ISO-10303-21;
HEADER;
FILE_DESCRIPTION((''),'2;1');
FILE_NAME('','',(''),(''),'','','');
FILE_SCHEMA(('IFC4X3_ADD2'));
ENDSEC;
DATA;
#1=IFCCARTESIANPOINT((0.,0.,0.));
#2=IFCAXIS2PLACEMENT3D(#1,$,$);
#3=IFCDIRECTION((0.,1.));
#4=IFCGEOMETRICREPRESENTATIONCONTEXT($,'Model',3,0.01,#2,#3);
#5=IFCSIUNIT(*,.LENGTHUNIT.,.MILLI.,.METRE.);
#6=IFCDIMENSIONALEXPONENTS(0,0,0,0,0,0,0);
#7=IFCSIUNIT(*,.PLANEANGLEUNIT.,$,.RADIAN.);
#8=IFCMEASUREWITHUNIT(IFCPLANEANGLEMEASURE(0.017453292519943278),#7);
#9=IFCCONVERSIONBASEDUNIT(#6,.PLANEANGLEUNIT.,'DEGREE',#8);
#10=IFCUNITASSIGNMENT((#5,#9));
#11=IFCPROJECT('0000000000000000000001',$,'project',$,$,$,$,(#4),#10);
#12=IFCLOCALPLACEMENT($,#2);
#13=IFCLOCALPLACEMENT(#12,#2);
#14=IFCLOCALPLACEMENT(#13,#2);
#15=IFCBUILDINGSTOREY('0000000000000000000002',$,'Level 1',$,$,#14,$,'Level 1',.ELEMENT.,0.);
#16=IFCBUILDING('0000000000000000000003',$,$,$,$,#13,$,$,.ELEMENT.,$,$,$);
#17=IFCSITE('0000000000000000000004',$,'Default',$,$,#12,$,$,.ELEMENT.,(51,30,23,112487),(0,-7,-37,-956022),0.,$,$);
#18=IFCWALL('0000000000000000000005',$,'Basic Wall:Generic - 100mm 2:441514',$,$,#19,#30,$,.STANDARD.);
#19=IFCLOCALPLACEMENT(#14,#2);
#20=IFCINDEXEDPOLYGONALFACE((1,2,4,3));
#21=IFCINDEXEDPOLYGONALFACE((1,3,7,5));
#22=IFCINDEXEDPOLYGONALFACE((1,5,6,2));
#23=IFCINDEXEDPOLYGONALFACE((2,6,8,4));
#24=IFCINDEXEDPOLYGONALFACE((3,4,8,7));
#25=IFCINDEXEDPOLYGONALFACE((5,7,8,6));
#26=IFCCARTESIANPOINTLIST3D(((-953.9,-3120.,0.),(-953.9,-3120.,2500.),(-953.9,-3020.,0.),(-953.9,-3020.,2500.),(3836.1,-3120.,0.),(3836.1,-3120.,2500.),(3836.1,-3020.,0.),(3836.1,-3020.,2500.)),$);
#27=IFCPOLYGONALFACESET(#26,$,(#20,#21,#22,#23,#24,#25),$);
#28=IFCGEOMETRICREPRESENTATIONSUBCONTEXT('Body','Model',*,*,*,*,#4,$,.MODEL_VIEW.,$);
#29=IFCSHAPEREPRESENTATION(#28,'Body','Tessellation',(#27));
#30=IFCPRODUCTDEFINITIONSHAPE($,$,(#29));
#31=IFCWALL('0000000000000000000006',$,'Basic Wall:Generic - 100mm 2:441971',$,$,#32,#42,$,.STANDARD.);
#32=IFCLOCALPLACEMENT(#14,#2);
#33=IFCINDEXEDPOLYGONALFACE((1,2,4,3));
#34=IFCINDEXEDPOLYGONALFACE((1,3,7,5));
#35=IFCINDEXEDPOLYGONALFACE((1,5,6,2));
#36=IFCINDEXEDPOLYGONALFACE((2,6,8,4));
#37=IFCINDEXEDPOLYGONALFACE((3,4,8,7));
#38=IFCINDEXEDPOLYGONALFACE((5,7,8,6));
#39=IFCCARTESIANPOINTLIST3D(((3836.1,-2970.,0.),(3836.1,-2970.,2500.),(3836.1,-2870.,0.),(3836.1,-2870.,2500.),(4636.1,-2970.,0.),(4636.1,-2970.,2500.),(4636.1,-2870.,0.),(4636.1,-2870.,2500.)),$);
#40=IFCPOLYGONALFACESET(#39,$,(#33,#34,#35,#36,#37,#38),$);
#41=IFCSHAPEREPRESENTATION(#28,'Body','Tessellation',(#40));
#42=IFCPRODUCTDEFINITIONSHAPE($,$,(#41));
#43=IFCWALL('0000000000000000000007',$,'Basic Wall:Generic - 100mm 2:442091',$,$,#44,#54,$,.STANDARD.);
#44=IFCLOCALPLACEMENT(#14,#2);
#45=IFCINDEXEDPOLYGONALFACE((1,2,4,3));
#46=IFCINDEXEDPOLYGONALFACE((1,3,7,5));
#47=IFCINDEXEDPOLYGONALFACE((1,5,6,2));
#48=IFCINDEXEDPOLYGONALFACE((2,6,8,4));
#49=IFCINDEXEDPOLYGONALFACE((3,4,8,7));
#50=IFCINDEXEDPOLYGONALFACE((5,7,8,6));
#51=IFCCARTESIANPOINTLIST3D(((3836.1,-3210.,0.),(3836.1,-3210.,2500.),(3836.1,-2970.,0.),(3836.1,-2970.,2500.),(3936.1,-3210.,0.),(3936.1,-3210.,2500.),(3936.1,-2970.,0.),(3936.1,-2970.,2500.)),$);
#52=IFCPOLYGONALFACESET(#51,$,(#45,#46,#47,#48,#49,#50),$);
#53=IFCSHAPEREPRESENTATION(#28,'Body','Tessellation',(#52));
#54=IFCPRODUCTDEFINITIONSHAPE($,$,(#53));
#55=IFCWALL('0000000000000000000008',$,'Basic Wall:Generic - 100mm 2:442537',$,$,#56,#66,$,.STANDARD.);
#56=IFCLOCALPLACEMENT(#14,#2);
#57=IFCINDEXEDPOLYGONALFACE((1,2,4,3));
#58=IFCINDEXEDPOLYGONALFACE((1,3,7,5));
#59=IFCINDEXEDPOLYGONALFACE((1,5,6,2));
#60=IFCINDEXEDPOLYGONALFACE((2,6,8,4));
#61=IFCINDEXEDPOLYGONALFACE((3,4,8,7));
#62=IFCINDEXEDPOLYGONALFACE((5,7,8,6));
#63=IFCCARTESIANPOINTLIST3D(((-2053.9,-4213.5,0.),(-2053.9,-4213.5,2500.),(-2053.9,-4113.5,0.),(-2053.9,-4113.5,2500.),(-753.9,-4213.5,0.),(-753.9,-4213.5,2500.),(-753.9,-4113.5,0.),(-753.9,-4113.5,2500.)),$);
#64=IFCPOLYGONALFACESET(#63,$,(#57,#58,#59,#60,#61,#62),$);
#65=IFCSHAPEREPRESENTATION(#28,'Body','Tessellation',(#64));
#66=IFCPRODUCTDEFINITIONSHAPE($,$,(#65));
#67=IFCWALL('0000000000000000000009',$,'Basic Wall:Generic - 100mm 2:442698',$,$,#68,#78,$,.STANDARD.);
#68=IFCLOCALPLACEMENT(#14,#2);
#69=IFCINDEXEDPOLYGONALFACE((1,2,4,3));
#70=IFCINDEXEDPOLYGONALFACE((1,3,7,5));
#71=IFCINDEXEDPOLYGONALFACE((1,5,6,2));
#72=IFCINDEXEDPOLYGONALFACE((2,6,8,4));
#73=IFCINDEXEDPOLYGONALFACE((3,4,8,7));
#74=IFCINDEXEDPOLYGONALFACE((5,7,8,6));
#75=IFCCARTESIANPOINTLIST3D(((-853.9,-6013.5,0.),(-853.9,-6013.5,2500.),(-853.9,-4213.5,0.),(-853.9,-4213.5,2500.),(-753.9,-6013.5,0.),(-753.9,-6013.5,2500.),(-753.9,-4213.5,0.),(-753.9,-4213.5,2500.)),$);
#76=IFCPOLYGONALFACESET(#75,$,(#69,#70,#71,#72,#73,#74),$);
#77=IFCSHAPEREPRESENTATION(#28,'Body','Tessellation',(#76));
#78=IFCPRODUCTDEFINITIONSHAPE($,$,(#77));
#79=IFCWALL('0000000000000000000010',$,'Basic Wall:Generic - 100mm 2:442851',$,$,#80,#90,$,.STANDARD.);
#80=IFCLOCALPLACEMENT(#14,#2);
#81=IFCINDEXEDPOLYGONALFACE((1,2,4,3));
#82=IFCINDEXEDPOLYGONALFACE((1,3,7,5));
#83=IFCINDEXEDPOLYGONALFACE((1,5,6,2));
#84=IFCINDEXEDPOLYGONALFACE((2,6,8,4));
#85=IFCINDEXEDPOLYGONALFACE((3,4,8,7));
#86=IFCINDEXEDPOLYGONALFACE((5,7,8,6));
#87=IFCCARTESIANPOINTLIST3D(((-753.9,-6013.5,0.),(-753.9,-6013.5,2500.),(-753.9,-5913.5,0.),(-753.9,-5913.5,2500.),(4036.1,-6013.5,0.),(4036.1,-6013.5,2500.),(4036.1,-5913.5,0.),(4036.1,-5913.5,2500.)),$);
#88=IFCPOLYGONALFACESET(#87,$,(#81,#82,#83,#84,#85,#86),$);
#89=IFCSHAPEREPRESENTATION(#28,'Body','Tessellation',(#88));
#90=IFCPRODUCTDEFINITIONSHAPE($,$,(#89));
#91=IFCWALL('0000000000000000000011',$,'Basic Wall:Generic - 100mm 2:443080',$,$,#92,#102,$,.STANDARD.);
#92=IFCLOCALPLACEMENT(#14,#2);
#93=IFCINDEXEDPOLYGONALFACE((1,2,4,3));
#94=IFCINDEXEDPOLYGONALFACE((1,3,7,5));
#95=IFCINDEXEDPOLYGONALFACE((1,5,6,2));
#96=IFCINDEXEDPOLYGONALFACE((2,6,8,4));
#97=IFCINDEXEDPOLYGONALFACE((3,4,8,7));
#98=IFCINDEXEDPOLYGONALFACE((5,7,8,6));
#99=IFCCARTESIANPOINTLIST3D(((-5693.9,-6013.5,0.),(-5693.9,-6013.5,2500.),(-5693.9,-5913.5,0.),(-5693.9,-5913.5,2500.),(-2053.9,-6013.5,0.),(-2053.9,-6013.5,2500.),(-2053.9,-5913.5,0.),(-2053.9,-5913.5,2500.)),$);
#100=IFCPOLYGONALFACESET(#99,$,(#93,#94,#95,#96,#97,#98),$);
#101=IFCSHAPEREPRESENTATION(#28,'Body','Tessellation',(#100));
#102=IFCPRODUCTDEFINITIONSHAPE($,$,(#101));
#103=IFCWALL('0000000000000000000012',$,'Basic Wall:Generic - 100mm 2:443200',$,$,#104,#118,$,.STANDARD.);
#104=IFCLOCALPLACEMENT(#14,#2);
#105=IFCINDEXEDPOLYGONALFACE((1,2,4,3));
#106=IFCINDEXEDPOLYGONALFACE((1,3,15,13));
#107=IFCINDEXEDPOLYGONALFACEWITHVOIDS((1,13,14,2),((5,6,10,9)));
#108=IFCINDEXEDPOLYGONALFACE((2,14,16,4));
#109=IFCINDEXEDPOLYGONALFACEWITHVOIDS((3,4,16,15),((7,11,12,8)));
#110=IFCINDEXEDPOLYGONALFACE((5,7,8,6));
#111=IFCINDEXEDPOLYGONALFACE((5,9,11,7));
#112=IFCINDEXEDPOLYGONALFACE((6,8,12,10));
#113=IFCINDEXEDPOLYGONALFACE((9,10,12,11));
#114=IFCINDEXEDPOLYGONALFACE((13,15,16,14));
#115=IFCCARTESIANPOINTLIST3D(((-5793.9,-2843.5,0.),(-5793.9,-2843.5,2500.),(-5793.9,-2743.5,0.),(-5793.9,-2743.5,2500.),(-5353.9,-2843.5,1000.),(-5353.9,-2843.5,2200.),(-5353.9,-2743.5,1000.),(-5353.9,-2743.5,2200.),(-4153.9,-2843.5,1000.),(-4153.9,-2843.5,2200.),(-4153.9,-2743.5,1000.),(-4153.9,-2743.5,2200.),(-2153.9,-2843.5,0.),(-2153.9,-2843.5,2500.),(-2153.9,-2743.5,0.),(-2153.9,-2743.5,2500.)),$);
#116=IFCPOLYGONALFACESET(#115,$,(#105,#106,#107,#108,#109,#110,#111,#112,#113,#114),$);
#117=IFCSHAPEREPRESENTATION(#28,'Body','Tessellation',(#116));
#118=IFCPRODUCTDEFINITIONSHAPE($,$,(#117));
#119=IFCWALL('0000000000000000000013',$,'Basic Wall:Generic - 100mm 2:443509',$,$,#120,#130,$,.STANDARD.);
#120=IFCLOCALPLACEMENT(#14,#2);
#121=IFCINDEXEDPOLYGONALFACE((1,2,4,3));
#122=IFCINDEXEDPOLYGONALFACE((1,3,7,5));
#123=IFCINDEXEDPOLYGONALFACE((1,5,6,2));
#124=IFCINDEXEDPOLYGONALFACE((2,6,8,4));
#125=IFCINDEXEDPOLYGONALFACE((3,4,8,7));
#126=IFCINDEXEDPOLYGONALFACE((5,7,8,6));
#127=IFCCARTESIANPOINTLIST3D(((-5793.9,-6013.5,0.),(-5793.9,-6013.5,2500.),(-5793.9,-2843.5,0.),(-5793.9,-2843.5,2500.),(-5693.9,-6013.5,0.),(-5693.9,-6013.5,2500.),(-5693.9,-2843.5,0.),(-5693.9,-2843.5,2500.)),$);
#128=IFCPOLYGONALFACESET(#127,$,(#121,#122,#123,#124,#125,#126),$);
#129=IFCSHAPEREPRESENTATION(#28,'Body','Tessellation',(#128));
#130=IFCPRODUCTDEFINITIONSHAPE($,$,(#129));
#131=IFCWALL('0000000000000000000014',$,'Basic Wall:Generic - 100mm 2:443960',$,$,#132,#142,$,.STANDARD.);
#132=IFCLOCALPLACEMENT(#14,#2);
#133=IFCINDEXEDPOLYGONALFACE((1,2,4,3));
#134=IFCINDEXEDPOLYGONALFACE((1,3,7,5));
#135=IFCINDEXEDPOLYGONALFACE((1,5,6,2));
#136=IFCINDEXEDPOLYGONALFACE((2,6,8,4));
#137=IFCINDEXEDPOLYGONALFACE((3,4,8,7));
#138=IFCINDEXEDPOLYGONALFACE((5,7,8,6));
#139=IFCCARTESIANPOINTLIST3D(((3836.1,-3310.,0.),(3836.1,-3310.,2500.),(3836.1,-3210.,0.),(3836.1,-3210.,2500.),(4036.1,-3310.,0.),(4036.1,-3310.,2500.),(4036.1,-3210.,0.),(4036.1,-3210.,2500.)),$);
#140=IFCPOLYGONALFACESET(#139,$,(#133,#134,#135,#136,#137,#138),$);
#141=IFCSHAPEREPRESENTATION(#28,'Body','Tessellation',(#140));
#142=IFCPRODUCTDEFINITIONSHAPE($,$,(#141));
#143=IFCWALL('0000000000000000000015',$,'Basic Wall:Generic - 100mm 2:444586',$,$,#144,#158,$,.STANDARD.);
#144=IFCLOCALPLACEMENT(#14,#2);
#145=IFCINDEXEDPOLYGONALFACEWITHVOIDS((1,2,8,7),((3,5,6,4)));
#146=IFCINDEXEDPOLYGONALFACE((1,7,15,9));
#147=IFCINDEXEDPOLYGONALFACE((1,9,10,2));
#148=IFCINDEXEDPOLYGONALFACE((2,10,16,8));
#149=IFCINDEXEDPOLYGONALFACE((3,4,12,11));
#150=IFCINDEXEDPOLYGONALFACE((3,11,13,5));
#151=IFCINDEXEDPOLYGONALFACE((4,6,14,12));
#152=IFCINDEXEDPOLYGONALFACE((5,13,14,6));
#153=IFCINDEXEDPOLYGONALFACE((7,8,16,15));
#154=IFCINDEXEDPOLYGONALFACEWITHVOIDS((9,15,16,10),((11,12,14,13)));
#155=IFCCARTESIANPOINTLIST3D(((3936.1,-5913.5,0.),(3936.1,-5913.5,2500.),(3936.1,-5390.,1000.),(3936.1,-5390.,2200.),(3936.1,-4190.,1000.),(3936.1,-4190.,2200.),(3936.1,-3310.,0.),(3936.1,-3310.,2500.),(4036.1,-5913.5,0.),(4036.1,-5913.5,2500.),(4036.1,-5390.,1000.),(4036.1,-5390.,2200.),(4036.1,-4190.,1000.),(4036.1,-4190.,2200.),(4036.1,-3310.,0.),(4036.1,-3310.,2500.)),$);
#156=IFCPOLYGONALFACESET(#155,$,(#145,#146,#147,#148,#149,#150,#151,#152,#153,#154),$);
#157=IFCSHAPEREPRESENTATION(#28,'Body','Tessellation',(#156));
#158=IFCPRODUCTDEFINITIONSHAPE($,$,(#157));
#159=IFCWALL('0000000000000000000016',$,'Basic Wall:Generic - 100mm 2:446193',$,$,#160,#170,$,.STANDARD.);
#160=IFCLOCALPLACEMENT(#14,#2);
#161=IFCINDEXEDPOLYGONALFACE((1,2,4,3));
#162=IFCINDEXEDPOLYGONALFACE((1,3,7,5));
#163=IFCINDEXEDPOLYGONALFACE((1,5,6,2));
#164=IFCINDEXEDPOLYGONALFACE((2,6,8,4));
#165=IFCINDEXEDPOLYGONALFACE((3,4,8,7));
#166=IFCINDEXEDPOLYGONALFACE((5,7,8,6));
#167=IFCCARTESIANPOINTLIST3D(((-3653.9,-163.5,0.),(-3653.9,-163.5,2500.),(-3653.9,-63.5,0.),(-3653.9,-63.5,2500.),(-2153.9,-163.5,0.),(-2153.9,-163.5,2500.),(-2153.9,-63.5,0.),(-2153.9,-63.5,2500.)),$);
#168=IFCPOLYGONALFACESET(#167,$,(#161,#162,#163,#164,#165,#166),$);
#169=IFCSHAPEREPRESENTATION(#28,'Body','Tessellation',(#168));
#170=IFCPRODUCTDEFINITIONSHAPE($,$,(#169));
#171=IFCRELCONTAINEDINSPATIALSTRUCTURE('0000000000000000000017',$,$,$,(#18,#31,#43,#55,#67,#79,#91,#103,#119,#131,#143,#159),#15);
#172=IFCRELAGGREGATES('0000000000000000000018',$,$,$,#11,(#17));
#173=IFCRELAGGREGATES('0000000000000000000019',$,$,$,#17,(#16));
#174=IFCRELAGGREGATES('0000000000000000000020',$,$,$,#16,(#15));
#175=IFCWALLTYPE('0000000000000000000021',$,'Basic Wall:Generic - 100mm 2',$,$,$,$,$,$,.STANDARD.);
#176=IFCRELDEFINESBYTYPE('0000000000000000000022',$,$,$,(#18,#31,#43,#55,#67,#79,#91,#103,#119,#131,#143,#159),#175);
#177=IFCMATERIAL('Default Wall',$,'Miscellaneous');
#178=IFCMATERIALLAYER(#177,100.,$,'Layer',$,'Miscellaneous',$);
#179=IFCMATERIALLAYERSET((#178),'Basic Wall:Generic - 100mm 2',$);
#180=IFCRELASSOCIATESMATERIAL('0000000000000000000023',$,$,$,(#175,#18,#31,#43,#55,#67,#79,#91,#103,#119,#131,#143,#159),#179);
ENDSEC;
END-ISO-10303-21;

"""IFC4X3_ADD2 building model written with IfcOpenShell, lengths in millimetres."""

from ifc_helpers import new_model, entity, si_unit, converted_unit, direction, frame, frame_2d, origin, place, context, subcontext, project, spatial, rectangle, extrude, material, layer, layer_set, type_object, element, save


model = new_model("IFC4X3_ADD2")

# Units and contexts
model_context = context("Model", 3, precision=0.01, world=origin(), true_north=direction((0.0, 1.0)))
body_context = subcontext(model_context, "Body", "Model", "MODEL_VIEW")
ifc_project = project(units=[si_unit("LENGTHUNIT", "METRE", prefix="MILLI"), converted_unit("PLANEANGLEUNIT", "DEGREE", entity("IfcPlaneAngleMeasure", 0.017453292519943278), si_unit("PLANEANGLEUNIT", "RADIAN"), dimensions=[0, 0, 0, 0, 0, 0, 0])], contexts=[model_context])

# Site, building, storey
site_placement = place(None, origin())
site = spatial("IfcSite", under=ifc_project, at=site_placement, Name="Default", CompositionType="ELEMENT", RefLatitude=(51, 30, 23, 112487), RefLongitude=(0, -7, -37, -956022), RefElevation=0.0)
building_placement = place(site_placement, origin())
building = spatial("IfcBuilding", under=site, at=building_placement, CompositionType="ELEMENT")
storey_placement = place(building_placement, origin())
storey = spatial("IfcBuildingStorey", under=building, at=storey_placement, Name="Level 1", LongName="Level 1", CompositionType="ELEMENT", Elevation=0.0)

# Walls
ifc_material = material(Name="Default Wall", Category="Miscellaneous")
ifc_layer = layer(ifc_material, 100.0, Name="Layer", Category="Miscellaneous")
ifc_layer_set = layer_set([ifc_layer], Name="Basic Wall:Generic - 100mm 2")
wall_type = type_object("IfcWallType", Name="Basic Wall:Generic - 100mm 2", PredefinedType="STANDARD", material=ifc_layer_set)
wall_1_placement = place(storey_placement, frame((-953.9, -3070.0, 0.0)))
element("IfcWall", 1, at=wall_1_placement, inside=storey, type_object=wall_type, material=ifc_layer_set, Name="Basic Wall:Generic - 100mm 2:441514", PredefinedType="STANDARD", context=body_context, shape_type="SweptSolid", body=[
    extrude(rectangle(XDim=4790.0, YDim=100.0, at=frame_2d((2395.0, 0.0), x_axis=(-1.0, 0.0))), origin(), (0.0, 0.0, 1.0), 2500.0),
])
wall_2_placement = place(storey_placement, frame((4636.1, -2920.0, 0.0), z_axis=(0.0, 0.0, 1.0), x_axis=(-1.0, 0.0, 0.0)))
element("IfcWall", 2, at=wall_2_placement, inside=storey, type_object=wall_type, material=ifc_layer_set, Name="Basic Wall:Generic - 100mm 2:441971", PredefinedType="STANDARD", context=body_context, shape_type="SweptSolid", body=[
    extrude(rectangle(XDim=800.0, YDim=100.0, at=frame_2d((400.0, 0.0), x_axis=(-1.0, 0.0))), origin(), (0.0, 0.0, 1.0), 2500.0),
])
wall_3_placement = place(storey_placement, frame((3886.1, -2970.0, 0.0), z_axis=(0.0, 0.0, 1.0), x_axis=(0.0, -1.0, 0.0)))
element("IfcWall", 3, at=wall_3_placement, inside=storey, type_object=wall_type, material=ifc_layer_set, Name="Basic Wall:Generic - 100mm 2:442091", PredefinedType="STANDARD", context=body_context, shape_type="SweptSolid", body=[
    extrude(rectangle(XDim=240.0, YDim=100.0, at=frame_2d((120.0, 0.0), x_axis=(-1.0, 0.0))), origin(), (0.0, 0.0, 1.0), 2500.0),
])
wall_4_placement = place(storey_placement, frame((-2053.9, -4163.5, 0.0)))
element("IfcWall", 4, at=wall_4_placement, inside=storey, type_object=wall_type, material=ifc_layer_set, Name="Basic Wall:Generic - 100mm 2:442537", PredefinedType="STANDARD", context=body_context, shape_type="SweptSolid", body=[
    extrude(rectangle(XDim=1300.0, YDim=100.0, at=frame_2d((650.0, 0.0), x_axis=(-1.0, 0.0))), origin(), (0.0, 0.0, 1.0), 2500.0),
])
wall_5_placement = place(storey_placement, frame((-803.9, -4213.5, 0.0), z_axis=(0.0, 0.0, 1.0), x_axis=(0.0, -1.0, 0.0)))
element("IfcWall", 5, at=wall_5_placement, inside=storey, type_object=wall_type, material=ifc_layer_set, Name="Basic Wall:Generic - 100mm 2:442698", PredefinedType="STANDARD", context=body_context, shape_type="SweptSolid", body=[
    extrude(rectangle(XDim=1800.0, YDim=100.0, at=frame_2d((900.0, 0.0), x_axis=(-1.0, 0.0))), origin(), (0.0, 0.0, 1.0), 2500.0),
])
wall_6_placement = place(storey_placement, frame((-753.9, -5963.5, 0.0)))
element("IfcWall", 6, at=wall_6_placement, inside=storey, type_object=wall_type, material=ifc_layer_set, Name="Basic Wall:Generic - 100mm 2:442851", PredefinedType="STANDARD", context=body_context, shape_type="SweptSolid", body=[
    extrude(rectangle(XDim=4790.0, YDim=100.0, at=frame_2d((2395.0, 0.0), x_axis=(-1.0, 0.0))), origin(), (0.0, 0.0, 1.0), 2500.0),
])
wall_7_placement = place(storey_placement, frame((-2053.9, -5963.5, 0.0), z_axis=(0.0, 0.0, 1.0), x_axis=(-1.0, 0.0, 0.0)))
element("IfcWall", 7, at=wall_7_placement, inside=storey, type_object=wall_type, material=ifc_layer_set, Name="Basic Wall:Generic - 100mm 2:443080", PredefinedType="STANDARD", context=body_context, shape_type="SweptSolid", body=[
    extrude(rectangle(XDim=3640.0, YDim=100.0, at=frame_2d((1820.0, 0.0), x_axis=(-1.0, 0.0))), origin(), (0.0, 0.0, 1.0), 2500.0),
])

# Wall, opening
wall_8_placement = place(storey_placement, frame((-2153.9, -2793.5, 0.0), z_axis=(0.0, 0.0, 1.0), x_axis=(-1.0, 0.0, 0.0)))
wall_8 = element("IfcWall", 8, at=wall_8_placement, inside=storey, type_object=wall_type, material=ifc_layer_set, Name="Basic Wall:Generic - 100mm 2:443200", PredefinedType="STANDARD", context=body_context, shape_type="SweptSolid", body=[
    extrude(rectangle(XDim=3640.0, YDim=100.0, at=frame_2d((1820.0, 0.0), x_axis=(-1.0, 0.0))), origin(), (0.0, 0.0, 1.0), 2500.0),
])
opening_1_placement = place(wall_8_placement, frame((2000.0, -50.0, 1000.0)))
element("IfcOpeningElement", 9, at=opening_1_placement, cuts=wall_8, PredefinedType="OPENING", context=body_context, shape_type="SweptSolid", body=[
    extrude(rectangle(XDim=1200.0, YDim=1200.0, at=frame_2d((600.0, 600.0), x_axis=(-1.0, 0.0))), frame((0.0, 0.0, 0.0), z_axis=(0.0, 1.0, 0.0), x_axis=(0.0, 0.0, 1.0)), (0.0, 0.0, 1.0), 100.0),
])

# Walls
wall_9_placement = place(storey_placement, frame((-5743.9, -2843.5, 0.0), z_axis=(0.0, 0.0, 1.0), x_axis=(0.0, -1.0, 0.0)))
element("IfcWall", 10, at=wall_9_placement, inside=storey, type_object=wall_type, material=ifc_layer_set, Name="Basic Wall:Generic - 100mm 2:443509", PredefinedType="STANDARD", context=body_context, shape_type="SweptSolid", body=[
    extrude(rectangle(XDim=3170.0, YDim=100.0, at=frame_2d((1585.0, 0.0), x_axis=(-1.0, 0.0))), origin(), (0.0, 0.0, 1.0), 2500.0),
])
wall_10_placement = place(storey_placement, frame((3836.1, -3260.0, 0.0)))
element("IfcWall", 11, at=wall_10_placement, inside=storey, type_object=wall_type, material=ifc_layer_set, Name="Basic Wall:Generic - 100mm 2:443960", PredefinedType="STANDARD", context=body_context, shape_type="SweptSolid", body=[
    extrude(rectangle(XDim=200.0, YDim=100.0, at=frame_2d((100.0, 0.0), x_axis=(-1.0, 0.0))), origin(), (0.0, 0.0, 1.0), 2500.0),
])

# Wall, opening
wall_11_placement = place(storey_placement, frame((3986.1, -3310.0, 0.0), z_axis=(0.0, 0.0, 1.0), x_axis=(0.0, -1.0, 0.0)))
wall_11 = element("IfcWall", 12, at=wall_11_placement, inside=storey, type_object=wall_type, material=ifc_layer_set, Name="Basic Wall:Generic - 100mm 2:444586", PredefinedType="STANDARD", context=body_context, shape_type="SweptSolid", body=[
    extrude(rectangle(XDim=2603.6, YDim=100.0, at=frame_2d((1301.8, 0.0), x_axis=(-1.0, 0.0))), origin(), (0.0, 0.0, 1.0), 2500.0),
])
opening_2_placement = place(wall_11_placement, frame((880.0, -50.0, 1000.0)))
element("IfcOpeningElement", 13, at=opening_2_placement, cuts=wall_11, PredefinedType="OPENING", context=body_context, shape_type="SweptSolid", body=[
    extrude(rectangle(XDim=1200.0, YDim=1200.0, at=frame_2d((600.0, 600.0), x_axis=(-1.0, 0.0))), frame((0.0, 0.0, 0.0), z_axis=(0.0, 1.0, 0.0), x_axis=(0.0, 0.0, 1.0)), (0.0, 0.0, 1.0), 100.0),
])

# Wall
wall_12_placement = place(storey_placement, frame((-3653.9, -113.5, 0.0)))
element("IfcWall", 14, at=wall_12_placement, inside=storey, type_object=wall_type, material=ifc_layer_set, Name="Basic Wall:Generic - 100mm 2:446193", PredefinedType="STANDARD", context=body_context, shape_type="SweptSolid", body=[
    extrude(rectangle(XDim=1500.0, YDim=100.0, at=frame_2d((750.0, 0.0), x_axis=(-1.0, 0.0))), origin(), (0.0, 0.0, 1.0), 2500.0),
])

save(model, "model.ifc")
